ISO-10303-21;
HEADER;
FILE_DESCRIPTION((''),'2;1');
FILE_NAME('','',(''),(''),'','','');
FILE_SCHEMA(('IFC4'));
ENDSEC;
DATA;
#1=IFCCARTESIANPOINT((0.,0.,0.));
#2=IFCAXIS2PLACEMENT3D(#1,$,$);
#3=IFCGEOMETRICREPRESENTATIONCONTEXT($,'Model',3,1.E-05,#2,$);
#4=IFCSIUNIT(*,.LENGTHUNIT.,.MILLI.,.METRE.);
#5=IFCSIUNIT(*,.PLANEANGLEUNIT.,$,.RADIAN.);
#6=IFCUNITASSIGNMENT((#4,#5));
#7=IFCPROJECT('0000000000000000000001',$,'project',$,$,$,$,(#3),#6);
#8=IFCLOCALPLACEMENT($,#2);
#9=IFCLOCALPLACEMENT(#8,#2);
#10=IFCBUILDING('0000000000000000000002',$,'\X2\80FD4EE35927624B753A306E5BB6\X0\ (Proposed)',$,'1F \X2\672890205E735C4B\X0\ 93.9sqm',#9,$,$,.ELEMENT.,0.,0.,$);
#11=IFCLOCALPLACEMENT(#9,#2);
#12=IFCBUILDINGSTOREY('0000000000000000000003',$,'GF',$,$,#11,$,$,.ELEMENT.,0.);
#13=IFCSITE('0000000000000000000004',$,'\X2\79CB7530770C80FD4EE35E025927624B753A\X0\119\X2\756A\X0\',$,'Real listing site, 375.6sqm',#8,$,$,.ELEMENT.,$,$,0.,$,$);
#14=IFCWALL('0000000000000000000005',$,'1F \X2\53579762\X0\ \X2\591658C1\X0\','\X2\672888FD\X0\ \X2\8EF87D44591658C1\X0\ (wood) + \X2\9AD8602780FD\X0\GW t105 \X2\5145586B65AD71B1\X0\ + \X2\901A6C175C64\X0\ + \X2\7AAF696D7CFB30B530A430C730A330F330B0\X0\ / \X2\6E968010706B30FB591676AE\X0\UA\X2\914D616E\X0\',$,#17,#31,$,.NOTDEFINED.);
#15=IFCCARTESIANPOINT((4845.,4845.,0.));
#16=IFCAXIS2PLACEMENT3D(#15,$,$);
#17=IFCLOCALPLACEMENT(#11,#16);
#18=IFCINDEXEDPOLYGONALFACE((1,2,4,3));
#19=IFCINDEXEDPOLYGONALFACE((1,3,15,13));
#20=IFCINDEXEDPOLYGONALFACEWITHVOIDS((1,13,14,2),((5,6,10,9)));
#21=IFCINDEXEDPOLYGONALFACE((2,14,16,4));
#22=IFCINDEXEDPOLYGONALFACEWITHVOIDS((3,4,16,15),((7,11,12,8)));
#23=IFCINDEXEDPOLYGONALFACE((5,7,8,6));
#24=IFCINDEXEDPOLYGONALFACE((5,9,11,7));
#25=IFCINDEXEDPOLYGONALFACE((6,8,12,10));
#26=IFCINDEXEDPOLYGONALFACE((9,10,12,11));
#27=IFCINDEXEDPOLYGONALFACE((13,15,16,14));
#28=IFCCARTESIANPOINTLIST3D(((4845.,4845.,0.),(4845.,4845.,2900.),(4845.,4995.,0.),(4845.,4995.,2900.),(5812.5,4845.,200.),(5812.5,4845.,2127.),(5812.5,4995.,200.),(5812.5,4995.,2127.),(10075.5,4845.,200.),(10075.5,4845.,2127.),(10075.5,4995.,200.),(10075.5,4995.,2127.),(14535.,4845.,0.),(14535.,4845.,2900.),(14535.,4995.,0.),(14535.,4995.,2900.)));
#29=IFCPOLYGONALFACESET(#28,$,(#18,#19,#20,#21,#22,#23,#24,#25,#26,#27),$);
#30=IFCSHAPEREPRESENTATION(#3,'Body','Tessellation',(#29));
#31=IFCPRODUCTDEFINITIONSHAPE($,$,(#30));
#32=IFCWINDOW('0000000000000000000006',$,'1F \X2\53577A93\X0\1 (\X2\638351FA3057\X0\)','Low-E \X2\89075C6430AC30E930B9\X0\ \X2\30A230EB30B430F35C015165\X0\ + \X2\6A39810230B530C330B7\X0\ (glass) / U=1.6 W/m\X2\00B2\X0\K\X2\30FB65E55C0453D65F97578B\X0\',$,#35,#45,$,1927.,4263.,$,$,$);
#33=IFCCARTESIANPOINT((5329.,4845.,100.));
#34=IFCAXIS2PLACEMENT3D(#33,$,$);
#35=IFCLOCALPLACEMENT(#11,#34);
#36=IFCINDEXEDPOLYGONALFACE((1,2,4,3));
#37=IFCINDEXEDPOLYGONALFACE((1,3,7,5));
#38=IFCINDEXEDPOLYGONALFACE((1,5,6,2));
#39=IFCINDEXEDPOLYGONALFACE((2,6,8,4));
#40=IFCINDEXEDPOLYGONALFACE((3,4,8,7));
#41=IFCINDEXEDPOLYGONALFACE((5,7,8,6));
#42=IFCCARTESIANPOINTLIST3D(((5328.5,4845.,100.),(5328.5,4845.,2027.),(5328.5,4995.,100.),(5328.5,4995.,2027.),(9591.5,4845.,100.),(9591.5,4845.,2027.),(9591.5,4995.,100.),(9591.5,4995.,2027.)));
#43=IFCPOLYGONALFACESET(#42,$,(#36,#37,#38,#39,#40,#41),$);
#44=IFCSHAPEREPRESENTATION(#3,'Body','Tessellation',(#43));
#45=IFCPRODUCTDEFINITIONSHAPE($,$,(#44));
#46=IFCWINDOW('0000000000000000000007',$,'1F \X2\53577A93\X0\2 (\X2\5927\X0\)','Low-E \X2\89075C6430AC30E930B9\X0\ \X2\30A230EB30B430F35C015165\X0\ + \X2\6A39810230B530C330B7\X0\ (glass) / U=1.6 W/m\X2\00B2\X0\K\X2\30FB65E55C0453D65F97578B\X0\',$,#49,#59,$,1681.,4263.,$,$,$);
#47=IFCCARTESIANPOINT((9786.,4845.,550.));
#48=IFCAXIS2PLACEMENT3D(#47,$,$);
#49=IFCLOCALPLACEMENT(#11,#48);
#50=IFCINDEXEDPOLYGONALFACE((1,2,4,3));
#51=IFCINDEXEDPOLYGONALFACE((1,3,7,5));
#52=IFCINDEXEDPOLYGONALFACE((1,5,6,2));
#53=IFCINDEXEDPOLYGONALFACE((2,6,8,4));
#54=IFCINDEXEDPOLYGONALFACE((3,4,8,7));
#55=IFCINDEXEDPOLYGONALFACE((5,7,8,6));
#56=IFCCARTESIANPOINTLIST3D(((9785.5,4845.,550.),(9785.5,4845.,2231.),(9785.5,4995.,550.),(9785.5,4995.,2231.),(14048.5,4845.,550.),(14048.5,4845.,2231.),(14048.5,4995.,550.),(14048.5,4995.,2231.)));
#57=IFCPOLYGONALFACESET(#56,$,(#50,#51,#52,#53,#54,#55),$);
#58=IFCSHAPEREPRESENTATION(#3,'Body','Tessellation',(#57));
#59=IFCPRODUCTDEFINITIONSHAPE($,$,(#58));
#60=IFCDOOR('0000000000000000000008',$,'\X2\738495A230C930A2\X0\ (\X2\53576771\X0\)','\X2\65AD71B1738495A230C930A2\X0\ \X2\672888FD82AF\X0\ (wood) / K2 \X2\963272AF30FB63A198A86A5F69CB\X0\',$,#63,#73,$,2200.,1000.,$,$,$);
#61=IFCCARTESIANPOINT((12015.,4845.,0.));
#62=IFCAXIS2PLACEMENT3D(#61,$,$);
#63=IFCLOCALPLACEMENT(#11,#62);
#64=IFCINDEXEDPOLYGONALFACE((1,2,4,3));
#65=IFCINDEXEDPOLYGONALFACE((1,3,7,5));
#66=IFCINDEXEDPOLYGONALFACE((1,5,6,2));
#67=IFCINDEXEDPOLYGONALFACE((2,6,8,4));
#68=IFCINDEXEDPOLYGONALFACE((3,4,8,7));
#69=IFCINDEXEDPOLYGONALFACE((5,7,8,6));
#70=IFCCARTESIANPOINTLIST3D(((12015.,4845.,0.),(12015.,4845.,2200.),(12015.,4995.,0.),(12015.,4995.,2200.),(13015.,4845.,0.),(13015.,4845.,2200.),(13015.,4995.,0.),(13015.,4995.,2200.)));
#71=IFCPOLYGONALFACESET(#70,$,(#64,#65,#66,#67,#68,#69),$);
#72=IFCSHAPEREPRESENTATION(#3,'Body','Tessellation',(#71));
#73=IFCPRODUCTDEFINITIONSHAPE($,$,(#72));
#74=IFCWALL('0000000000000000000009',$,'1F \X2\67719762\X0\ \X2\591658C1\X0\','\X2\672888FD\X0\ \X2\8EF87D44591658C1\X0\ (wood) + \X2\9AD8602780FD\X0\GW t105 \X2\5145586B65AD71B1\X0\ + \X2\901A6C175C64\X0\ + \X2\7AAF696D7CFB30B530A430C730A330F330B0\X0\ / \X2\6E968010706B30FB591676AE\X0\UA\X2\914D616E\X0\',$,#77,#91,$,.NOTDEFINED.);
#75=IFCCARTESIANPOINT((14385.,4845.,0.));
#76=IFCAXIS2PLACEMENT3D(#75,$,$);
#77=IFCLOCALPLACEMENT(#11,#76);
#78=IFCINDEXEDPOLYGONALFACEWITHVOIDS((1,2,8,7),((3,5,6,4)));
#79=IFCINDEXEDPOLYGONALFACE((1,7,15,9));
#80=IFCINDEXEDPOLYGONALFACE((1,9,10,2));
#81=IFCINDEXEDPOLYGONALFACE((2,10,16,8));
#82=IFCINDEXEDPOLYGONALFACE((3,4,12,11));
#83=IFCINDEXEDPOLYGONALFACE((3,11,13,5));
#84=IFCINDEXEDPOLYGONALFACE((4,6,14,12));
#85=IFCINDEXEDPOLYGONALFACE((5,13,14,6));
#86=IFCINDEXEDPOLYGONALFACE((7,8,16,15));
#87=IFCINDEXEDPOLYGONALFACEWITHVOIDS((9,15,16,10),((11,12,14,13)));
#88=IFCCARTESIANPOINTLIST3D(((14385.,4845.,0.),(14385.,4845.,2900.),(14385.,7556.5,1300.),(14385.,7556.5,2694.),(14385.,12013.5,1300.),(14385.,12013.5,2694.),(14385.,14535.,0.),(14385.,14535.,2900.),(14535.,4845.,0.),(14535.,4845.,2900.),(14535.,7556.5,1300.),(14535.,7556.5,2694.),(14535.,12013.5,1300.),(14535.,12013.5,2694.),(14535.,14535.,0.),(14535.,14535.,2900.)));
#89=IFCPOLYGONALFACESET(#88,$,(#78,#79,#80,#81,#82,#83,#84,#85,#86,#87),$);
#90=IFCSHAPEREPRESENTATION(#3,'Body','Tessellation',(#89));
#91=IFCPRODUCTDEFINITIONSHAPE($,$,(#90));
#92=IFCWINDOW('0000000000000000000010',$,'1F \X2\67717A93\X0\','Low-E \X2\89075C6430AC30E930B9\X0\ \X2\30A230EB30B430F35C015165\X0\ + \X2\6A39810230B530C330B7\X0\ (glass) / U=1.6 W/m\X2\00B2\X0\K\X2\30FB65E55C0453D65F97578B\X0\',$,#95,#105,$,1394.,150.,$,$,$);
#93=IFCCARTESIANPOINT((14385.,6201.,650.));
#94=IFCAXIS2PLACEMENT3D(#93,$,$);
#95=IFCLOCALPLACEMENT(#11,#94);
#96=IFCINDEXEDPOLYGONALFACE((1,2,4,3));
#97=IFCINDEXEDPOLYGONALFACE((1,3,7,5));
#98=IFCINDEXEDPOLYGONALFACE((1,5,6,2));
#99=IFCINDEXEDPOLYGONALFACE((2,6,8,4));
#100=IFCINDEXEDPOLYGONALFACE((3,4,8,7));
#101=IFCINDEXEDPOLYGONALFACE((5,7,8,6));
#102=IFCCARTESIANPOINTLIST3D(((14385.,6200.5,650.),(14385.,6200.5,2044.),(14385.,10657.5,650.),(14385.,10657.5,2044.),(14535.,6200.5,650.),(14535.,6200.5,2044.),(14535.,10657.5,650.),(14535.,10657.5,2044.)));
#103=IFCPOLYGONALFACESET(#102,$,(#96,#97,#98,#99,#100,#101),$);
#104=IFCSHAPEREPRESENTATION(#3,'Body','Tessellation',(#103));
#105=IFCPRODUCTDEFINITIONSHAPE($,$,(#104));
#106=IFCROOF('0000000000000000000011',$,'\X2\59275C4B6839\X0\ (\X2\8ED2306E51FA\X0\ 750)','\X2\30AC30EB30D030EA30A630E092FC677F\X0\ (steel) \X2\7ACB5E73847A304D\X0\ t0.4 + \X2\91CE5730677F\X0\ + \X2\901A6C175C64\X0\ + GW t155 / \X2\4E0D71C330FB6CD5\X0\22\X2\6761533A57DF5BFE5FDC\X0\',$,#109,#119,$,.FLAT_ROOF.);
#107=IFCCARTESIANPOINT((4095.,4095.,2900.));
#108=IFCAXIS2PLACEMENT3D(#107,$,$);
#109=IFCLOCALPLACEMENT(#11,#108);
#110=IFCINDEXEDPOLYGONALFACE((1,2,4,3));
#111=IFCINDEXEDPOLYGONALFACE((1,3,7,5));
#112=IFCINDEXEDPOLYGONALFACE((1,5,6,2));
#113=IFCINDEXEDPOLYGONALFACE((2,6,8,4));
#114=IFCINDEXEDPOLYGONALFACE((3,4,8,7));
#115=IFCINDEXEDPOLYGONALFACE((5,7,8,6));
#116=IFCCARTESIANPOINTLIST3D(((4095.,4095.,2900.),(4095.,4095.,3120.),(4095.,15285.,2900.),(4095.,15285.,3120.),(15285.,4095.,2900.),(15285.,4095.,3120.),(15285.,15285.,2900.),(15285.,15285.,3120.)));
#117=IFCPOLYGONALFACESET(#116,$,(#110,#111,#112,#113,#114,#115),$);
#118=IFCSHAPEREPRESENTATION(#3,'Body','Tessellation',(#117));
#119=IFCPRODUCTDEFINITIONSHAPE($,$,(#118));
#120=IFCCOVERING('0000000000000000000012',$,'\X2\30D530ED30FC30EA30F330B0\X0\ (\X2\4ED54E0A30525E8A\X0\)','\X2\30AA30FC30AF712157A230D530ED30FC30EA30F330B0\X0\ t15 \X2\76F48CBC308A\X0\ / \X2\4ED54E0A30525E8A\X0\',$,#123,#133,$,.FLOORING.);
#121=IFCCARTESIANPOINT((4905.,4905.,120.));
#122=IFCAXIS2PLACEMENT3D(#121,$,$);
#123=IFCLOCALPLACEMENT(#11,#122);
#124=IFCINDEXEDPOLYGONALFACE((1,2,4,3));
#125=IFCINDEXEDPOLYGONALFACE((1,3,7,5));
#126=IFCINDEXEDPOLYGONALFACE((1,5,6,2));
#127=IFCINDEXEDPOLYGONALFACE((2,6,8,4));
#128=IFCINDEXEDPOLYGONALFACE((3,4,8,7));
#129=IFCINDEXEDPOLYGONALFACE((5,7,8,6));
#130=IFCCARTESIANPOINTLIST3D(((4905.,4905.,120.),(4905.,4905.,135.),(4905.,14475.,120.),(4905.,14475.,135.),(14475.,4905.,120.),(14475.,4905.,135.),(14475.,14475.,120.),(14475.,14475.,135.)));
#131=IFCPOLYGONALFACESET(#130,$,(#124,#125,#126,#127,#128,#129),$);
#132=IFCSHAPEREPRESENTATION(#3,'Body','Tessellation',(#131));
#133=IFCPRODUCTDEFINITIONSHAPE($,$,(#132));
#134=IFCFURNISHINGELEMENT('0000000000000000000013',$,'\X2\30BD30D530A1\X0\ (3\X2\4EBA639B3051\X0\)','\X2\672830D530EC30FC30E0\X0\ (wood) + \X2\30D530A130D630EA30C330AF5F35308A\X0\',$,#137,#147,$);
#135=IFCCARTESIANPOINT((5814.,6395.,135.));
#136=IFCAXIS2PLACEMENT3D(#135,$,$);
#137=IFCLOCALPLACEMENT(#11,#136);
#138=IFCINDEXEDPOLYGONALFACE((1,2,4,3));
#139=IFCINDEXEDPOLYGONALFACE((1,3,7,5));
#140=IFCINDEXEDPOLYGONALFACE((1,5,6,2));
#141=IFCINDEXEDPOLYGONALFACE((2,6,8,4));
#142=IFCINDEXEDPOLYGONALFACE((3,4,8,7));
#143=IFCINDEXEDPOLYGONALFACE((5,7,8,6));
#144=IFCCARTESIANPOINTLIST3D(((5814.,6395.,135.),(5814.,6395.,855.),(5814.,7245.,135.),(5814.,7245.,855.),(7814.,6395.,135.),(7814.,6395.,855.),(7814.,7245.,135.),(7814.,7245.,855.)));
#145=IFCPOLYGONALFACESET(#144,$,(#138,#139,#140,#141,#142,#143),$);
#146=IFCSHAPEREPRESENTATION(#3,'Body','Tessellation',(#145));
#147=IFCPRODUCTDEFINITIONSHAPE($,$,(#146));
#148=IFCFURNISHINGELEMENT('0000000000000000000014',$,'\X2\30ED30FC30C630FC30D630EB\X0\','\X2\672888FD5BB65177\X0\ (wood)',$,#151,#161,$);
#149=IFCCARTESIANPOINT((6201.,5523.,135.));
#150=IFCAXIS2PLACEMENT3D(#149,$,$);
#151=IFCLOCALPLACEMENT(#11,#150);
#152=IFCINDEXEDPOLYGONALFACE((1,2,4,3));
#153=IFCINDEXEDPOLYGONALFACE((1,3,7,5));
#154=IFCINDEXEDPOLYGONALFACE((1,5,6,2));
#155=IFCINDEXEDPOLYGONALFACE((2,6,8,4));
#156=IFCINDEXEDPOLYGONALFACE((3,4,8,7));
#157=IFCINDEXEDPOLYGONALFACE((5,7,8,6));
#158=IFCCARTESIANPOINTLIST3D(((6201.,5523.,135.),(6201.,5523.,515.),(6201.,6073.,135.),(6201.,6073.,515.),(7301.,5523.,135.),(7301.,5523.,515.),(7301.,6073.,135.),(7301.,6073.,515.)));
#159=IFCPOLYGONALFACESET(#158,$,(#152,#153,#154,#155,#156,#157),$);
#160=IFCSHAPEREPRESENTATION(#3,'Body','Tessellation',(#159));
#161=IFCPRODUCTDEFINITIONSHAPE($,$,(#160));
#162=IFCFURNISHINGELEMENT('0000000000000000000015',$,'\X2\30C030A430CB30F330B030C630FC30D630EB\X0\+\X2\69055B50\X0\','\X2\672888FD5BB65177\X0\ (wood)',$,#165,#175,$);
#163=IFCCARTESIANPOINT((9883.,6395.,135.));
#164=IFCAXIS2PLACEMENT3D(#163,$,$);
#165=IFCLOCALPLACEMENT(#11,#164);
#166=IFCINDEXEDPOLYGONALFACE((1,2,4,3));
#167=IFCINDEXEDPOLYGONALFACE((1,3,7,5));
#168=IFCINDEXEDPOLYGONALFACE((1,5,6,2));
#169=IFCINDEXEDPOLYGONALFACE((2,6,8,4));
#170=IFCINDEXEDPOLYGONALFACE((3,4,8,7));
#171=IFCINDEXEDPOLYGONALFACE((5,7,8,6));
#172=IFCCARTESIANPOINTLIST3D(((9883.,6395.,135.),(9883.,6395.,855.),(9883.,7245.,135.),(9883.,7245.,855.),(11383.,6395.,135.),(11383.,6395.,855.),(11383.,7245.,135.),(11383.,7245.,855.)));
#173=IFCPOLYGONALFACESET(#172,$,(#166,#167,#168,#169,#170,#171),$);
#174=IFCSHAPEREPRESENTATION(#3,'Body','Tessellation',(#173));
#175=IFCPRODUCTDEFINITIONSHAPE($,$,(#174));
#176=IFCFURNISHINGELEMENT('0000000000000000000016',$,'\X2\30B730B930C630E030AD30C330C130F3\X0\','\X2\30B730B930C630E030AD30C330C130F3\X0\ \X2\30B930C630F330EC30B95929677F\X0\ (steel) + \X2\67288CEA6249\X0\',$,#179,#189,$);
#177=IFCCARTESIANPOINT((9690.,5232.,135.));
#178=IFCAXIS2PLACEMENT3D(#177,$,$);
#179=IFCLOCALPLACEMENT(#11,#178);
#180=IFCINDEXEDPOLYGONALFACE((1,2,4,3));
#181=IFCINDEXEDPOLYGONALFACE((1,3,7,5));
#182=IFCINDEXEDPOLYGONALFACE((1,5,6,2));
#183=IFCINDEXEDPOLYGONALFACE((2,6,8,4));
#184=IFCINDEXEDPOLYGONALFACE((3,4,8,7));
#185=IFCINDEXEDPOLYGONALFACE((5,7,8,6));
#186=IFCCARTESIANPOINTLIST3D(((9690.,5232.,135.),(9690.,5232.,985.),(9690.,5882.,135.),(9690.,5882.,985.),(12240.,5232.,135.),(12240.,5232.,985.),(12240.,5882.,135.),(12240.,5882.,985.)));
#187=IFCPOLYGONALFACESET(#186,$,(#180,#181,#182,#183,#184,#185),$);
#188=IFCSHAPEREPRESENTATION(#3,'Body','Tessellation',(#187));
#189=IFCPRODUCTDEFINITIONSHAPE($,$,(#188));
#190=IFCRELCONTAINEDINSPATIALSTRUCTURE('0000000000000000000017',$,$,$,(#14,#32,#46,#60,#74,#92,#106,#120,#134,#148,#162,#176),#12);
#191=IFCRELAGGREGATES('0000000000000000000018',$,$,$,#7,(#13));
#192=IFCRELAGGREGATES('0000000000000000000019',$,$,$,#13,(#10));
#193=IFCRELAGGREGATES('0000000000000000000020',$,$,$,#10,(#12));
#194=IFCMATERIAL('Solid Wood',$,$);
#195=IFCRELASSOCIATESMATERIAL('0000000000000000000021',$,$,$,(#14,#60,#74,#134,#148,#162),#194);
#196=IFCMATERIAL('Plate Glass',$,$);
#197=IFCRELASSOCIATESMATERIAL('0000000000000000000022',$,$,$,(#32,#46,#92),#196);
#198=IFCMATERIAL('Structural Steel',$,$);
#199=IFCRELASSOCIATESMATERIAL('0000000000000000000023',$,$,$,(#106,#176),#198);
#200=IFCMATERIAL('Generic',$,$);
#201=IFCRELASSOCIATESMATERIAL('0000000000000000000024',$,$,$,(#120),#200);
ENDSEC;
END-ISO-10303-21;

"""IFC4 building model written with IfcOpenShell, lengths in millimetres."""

from ifc_helpers import new_model, si_unit, frame, frame_2d, origin, place, context, project, spatial, rectangle, extrude, material, element, fill, save


model = new_model("IFC4")

# Units and contexts
model_context = context("Model", 3, precision=1e-05, world=origin())
ifc_project = project(units=[si_unit("LENGTHUNIT", "METRE", prefix="MILLI"), si_unit("PLANEANGLEUNIT", "RADIAN")], contexts=[model_context])

# Site, building, storey
site_placement = place(None, origin())
site = spatial("IfcSite", under=ifc_project, at=site_placement, Name="秋田県能代市大手町119番", ObjectType="Real listing site, 375.6sqm", CompositionType="ELEMENT", RefElevation=0.0)
building_placement = place(site_placement, origin())
building = spatial("IfcBuilding", under=site, at=building_placement, Name="能代大手町の家 (Proposed)", ObjectType="1F 木造平屋 93.9sqm", CompositionType="ELEMENT", ElevationOfRefHeight=0.0, ElevationOfTerrain=0.0)
storey_placement = place(building_placement, origin())
storey = spatial("IfcBuildingStorey", under=building, at=storey_placement, Name="GF", CompositionType="ELEMENT", Elevation=0.0)

# Shared definitions
ifc_material_1 = material(Name="Solid Wood")

# Wall, openings, windows, door
wall_1_placement = place(storey_placement, frame((4845.0, 4845.0, 0.0)))
wall_1 = element("IfcWall", 1, at=wall_1_placement, inside=storey, material=ifc_material_1, Name="1F 南面 外壁", Description="木製 軸組外壁 (wood) + 高性能GW t105 充填断熱 + 通気層 + 窯業系サイディング / 準耐火・外皮UA配慮", PredefinedType="NOTDEFINED", context=model_context, shape_type="SweptSolid", body=[
    extrude(rectangle(XDim=9690.0, YDim=150.0, at=frame_2d((4845.0, 75.0))), frame((4845.0, 4845.0, 0.0)), (0.0, 0.0, 1.0), 2900.0),
])
opening_1_placement = place(storey_placement, frame((5329.0, 4845.0, 100.0)))
opening_1 = element("IfcOpeningElement", 2, at=opening_1_placement, cuts=wall_1, PredefinedType="NOTDEFINED", context=model_context, shape_type="SweptSolid", body=[
    extrude(rectangle(XDim=4263.0, YDim=150.0, at=frame_2d((2131.0, 75.0))), frame((5329.0, 4845.0, 100.0)), (0.0, 0.0, 1.0), 1927.0),
])
opening_2_placement = place(storey_placement, frame((9786.0, 4845.0, 550.0)))
opening_2 = element("IfcOpeningElement", 3, at=opening_2_placement, cuts=wall_1, PredefinedType="NOTDEFINED", context=model_context, shape_type="SweptSolid", body=[
    extrude(rectangle(XDim=4263.0, YDim=150.0, at=frame_2d((2131.0, 75.0))), frame((9786.0, 4845.0, 550.0)), (0.0, 0.0, 1.0), 1681.0),
])
opening_3_placement = place(storey_placement, frame((12015.0, 4845.0, 0.0)))
opening_3 = element("IfcOpeningElement", 4, at=opening_3_placement, cuts=wall_1, PredefinedType="NOTDEFINED", context=model_context, shape_type="SweptSolid", body=[
    extrude(rectangle(XDim=1000.0, YDim=150.0, at=frame_2d((500.0, 75.0))), frame((12015.0, 4845.0, 0.0)), (0.0, 0.0, 1.0), 2200.0),
])
ifc_material_2 = material(Name="Plate Glass")
window_1_placement = place(storey_placement, frame((5329.0, 4845.0, 100.0)))
window_1 = element("IfcWindow", 5, at=window_1_placement, inside=storey, material=ifc_material_2, Name="1F 南窓1 (掃出し)", Description="Low-E 複層ガラス アルゴン封入 + 樹脂サッシ (glass) / U=1.6 W/m²K・日射取得型", OverallHeight=1927.0, OverallWidth=4263.0, context=model_context, shape_type="SweptSolid", body=[
    extrude(rectangle(XDim=4263.0, YDim=150.0, at=frame_2d((2131.0, 75.0))), frame((5329.0, 4845.0, 100.0)), (0.0, 0.0, 1.0), 1927.0),
])
fill(opening_1, window_1)
window_2_placement = place(storey_placement, frame((9786.0, 4845.0, 550.0)))
window_2 = element("IfcWindow", 6, at=window_2_placement, inside=storey, material=ifc_material_2, Name="1F 南窓2 (大)", Description="Low-E 複層ガラス アルゴン封入 + 樹脂サッシ (glass) / U=1.6 W/m²K・日射取得型", OverallHeight=1681.0, OverallWidth=4263.0, context=model_context, shape_type="SweptSolid", body=[
    extrude(rectangle(XDim=4263.0, YDim=150.0, at=frame_2d((2131.0, 75.0))), frame((9786.0, 4845.0, 550.0)), (0.0, 0.0, 1.0), 1681.0),
])
fill(opening_2, window_2)
door_placement = place(storey_placement, frame((12015.0, 4845.0, 0.0)))
door = element("IfcDoor", 7, at=door_placement, inside=storey, material=ifc_material_1, Name="玄関ドア (南東)", Description="断熱玄関ドア 木製芯 (wood) / K2 防犯・採風機構", OverallHeight=2200.0, OverallWidth=1000.0, context=model_context, shape_type="SweptSolid", body=[
    extrude(rectangle(XDim=1000.0, YDim=150.0, at=frame_2d((500.0, 75.0))), frame((12015.0, 4845.0, 0.0)), (0.0, 0.0, 1.0), 2200.0),
])
fill(opening_3, door)

# Wall, opening, window
wall_2_placement = place(storey_placement, frame((14385.0, 4845.0, 0.0)))
wall_2 = element("IfcWall", 8, at=wall_2_placement, inside=storey, material=ifc_material_1, Name="1F 東面 外壁", Description="木製 軸組外壁 (wood) + 高性能GW t105 充填断熱 + 通気層 + 窯業系サイディング / 準耐火・外皮UA配慮", PredefinedType="NOTDEFINED", context=model_context, shape_type="SweptSolid", body=[
    extrude(rectangle(XDim=150.0, YDim=9690.0, at=frame_2d((75.0, 4845.0))), frame((14385.0, 4845.0, 0.0)), (0.0, 0.0, 1.0), 2900.0),
])
opening_4_placement = place(storey_placement, frame((14385.0, 6201.0, 650.0)))
opening_4 = element("IfcOpeningElement", 9, at=opening_4_placement, cuts=wall_2, PredefinedType="NOTDEFINED", context=model_context, shape_type="SweptSolid", body=[
    extrude(rectangle(XDim=150.0, YDim=4457.0, at=frame_2d((75.0, 2228.0))), frame((14385.0, 6201.0, 650.0)), (0.0, 0.0, 1.0), 1394.0),
])
window_3_placement = place(storey_placement, frame((14385.0, 6201.0, 650.0)))
window_3 = element("IfcWindow", 10, at=window_3_placement, inside=storey, material=ifc_material_2, Name="1F 東窓", Description="Low-E 複層ガラス アルゴン封入 + 樹脂サッシ (glass) / U=1.6 W/m²K・日射取得型", OverallHeight=1394.0, OverallWidth=150.0, context=model_context, shape_type="SweptSolid", body=[
    extrude(rectangle(XDim=150.0, YDim=4457.0, at=frame_2d((75.0, 2228.0))), frame((14385.0, 6201.0, 650.0)), (0.0, 0.0, 1.0), 1394.0),
])
fill(opening_4, window_3)

# Roof
ifc_material_3 = material(Name="Structural Steel")
roof_placement = place(storey_placement, frame((4095.0, 4095.0, 2900.0)))
element("IfcRoof", 11, at=roof_placement, inside=storey, material=ifc_material_3, Name="大屋根 (軒の出 750)", Description="ガルバリウム鋼板 (steel) 立平葺き t0.4 + 野地板 + 通気層 + GW t155 / 不燃・法22条区域対応", PredefinedType="FLAT_ROOF", context=model_context, shape_type="SweptSolid", body=[
    extrude(rectangle(XDim=11190.0, YDim=11190.0, at=frame_2d((5595.0, 5595.0))), frame((4095.0, 4095.0, 2900.0)), (0.0, 0.0, 1.0), 220.0),
])

# Covering
ifc_material_4 = material(Name="Generic")
covering_placement = place(storey_placement, frame((4905.0, 4905.0, 120.0)))
element("IfcCovering", 12, at=covering_placement, inside=storey, material=ifc_material_4, Name="フローリング (仕上げ床)", Description="オーク無垢フローリング t15 直貼り / 仕上げ床", PredefinedType="FLOORING", context=model_context, shape_type="SweptSolid", body=[
    extrude(rectangle(XDim=9570.0, YDim=9570.0, at=frame_2d((4785.0, 4785.0))), frame((4905.0, 4905.0, 120.0)), (0.0, 0.0, 1.0), 15.0),
])

# Furnishing elements
furnishing_1_placement = place(storey_placement, frame((5814.0, 6395.0, 135.0)))
element("IfcFurnishingElement", 13, at=furnishing_1_placement, inside=storey, material=ifc_material_1, Name="ソファ (3人掛け)", Description="木フレーム (wood) + ファブリック張り", context=model_context, shape_type="SweptSolid", body=[
    extrude(rectangle(XDim=2000.0, YDim=850.0, at=frame_2d((1000.0, 425.0))), frame((5814.0, 6395.0, 135.0)), (0.0, 0.0, 1.0), 720.0),
])
furnishing_2_placement = place(storey_placement, frame((6201.0, 5523.0, 135.0)))
element("IfcFurnishingElement", 14, at=furnishing_2_placement, inside=storey, material=ifc_material_1, Name="ローテーブル", Description="木製家具 (wood)", context=model_context, shape_type="SweptSolid", body=[
    extrude(rectangle(XDim=1100.0, YDim=550.0, at=frame_2d((550.0, 275.0))), frame((6201.0, 5523.0, 135.0)), (0.0, 0.0, 1.0), 380.0),
])
furnishing_3_placement = place(storey_placement, frame((9883.0, 6395.0, 135.0)))
element("IfcFurnishingElement", 15, at=furnishing_3_placement, inside=storey, material=ifc_material_1, Name="ダイニングテーブル+椅子", Description="木製家具 (wood)", context=model_context, shape_type="SweptSolid", body=[
    extrude(rectangle(XDim=1500.0, YDim=850.0, at=frame_2d((750.0, 425.0))), frame((9883.0, 6395.0, 135.0)), (0.0, 0.0, 1.0), 720.0),
])
furnishing_4_placement = place(storey_placement, frame((9690.0, 5232.0, 135.0)))
element("IfcFurnishingElement", 16, at=furnishing_4_placement, inside=storey, material=ifc_material_3, Name="システムキッチン", Description="システムキッチン ステンレス天板 (steel) + 木質扉", context=model_context, shape_type="SweptSolid", body=[
    extrude(rectangle(XDim=2550.0, YDim=650.0, at=frame_2d((1275.0, 325.0))), frame((9690.0, 5232.0, 135.0)), (0.0, 0.0, 1.0), 850.0),
])

save(model, "model.ifc")
